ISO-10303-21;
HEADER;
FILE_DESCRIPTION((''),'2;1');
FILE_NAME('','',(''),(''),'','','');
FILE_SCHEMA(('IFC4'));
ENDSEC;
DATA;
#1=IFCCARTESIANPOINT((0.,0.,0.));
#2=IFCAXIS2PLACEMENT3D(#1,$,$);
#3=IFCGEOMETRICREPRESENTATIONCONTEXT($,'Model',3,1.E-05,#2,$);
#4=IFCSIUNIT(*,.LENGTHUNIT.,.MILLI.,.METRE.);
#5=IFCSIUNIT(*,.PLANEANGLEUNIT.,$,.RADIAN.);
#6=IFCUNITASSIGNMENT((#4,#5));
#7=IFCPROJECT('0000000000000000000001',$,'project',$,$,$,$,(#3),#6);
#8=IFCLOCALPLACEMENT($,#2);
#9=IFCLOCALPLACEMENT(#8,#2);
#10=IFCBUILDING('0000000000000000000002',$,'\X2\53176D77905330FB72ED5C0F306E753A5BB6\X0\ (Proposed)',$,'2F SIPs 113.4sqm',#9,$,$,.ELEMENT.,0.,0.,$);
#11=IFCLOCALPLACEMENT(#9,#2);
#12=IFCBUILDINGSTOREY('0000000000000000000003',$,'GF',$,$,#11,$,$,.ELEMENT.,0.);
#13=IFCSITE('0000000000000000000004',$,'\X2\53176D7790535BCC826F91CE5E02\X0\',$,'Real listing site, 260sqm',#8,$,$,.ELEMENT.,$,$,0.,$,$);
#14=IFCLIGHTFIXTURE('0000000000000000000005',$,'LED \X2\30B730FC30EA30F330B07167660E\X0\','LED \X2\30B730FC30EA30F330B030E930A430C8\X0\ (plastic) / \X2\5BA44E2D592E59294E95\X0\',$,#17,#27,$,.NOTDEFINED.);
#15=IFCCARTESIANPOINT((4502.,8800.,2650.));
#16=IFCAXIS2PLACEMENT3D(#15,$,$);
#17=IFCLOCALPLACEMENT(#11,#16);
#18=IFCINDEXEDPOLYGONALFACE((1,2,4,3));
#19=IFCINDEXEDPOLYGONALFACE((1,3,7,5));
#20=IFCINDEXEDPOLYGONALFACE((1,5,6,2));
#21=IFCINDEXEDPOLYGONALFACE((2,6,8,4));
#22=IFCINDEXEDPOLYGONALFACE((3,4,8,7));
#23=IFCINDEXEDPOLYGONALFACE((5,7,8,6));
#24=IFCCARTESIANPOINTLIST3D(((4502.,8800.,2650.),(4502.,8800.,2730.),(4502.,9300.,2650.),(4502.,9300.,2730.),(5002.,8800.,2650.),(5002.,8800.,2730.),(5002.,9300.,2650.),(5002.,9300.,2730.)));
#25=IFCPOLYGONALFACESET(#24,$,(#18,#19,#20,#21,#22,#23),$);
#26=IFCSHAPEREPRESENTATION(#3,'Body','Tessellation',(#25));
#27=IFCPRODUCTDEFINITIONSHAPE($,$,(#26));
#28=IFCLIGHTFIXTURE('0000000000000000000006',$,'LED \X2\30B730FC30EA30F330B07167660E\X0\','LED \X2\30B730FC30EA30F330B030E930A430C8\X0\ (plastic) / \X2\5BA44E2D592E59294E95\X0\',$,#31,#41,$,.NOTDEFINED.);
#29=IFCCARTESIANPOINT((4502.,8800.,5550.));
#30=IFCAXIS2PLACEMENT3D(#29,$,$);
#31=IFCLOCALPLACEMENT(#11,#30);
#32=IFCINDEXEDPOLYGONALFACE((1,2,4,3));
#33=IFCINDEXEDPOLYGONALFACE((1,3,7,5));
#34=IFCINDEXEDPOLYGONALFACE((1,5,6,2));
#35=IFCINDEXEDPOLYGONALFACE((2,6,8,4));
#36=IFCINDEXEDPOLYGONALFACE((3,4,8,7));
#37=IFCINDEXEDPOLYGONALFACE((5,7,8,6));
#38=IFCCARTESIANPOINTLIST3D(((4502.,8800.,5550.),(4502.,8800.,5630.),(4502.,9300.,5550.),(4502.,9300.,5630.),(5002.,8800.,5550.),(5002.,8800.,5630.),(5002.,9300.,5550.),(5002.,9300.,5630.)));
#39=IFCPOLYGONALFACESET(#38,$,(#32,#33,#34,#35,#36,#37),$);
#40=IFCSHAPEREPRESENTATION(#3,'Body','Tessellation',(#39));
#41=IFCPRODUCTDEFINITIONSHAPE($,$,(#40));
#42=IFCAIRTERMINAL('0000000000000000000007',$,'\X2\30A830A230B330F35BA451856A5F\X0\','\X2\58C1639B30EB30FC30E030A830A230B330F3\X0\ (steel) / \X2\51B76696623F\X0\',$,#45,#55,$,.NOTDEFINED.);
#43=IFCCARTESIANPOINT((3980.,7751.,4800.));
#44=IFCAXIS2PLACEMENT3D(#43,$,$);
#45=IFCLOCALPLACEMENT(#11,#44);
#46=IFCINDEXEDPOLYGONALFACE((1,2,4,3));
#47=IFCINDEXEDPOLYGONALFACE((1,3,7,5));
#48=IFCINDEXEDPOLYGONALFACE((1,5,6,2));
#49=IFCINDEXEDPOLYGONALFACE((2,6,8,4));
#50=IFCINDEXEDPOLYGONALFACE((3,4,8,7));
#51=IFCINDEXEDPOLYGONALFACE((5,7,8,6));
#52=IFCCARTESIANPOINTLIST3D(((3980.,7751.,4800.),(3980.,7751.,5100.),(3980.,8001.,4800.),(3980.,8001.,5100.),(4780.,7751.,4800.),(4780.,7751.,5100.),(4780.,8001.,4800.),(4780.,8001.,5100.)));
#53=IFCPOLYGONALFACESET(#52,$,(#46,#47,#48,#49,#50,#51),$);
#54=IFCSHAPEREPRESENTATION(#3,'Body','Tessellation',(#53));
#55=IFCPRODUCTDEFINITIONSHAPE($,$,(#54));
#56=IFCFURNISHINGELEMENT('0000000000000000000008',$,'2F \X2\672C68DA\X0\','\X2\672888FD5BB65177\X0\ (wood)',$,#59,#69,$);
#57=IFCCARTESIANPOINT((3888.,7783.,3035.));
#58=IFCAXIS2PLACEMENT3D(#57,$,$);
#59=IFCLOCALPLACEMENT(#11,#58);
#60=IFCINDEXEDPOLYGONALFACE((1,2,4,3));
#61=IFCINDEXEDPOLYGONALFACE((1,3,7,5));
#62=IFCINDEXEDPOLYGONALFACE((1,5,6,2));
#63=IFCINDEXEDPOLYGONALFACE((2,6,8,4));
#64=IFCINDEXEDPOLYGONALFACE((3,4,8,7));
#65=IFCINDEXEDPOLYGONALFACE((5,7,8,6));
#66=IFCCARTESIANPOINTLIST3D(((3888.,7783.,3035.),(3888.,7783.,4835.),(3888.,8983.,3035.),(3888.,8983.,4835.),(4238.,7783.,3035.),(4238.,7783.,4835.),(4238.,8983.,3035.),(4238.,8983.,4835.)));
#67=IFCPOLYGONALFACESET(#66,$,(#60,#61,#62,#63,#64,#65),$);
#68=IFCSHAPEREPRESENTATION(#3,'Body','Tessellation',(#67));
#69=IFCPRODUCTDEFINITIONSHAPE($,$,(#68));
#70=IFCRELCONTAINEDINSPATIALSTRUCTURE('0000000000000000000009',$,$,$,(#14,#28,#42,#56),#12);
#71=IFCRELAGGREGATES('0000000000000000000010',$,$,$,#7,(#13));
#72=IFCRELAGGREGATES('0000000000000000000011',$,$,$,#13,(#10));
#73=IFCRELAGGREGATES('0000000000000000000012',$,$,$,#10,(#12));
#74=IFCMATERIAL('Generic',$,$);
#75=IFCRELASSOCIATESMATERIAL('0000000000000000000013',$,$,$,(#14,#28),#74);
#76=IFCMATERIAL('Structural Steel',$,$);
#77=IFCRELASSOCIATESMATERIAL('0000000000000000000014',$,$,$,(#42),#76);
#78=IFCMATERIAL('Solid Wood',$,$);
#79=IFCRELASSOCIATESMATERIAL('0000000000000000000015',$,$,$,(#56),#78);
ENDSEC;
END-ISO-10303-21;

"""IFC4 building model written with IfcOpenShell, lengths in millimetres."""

from ifc_helpers import new_model, si_unit, frame, frame_2d, origin, place, context, project, spatial, rectangle, extrude, material, element, save


model = new_model("IFC4")

# Units and contexts
model_context = context("Model", 3, precision=1e-05, world=origin())
ifc_project = project(units=[si_unit("LENGTHUNIT", "METRE", prefix="MILLI"), si_unit("PLANEANGLEUNIT", "RADIAN")], contexts=[model_context])

# Site, building, storey
site_placement = place(None, origin())
site = spatial("IfcSite", under=ifc_project, at=site_placement, Name="北海道富良野市", ObjectType="Real listing site, 260sqm", CompositionType="ELEMENT", RefElevation=0.0)
building_placement = place(site_placement, origin())
building = spatial("IfcBuilding", under=site, at=building_placement, Name="北海道・狭小の町家 (Proposed)", ObjectType="2F SIPs 113.4sqm", CompositionType="ELEMENT", ElevationOfRefHeight=0.0, ElevationOfTerrain=0.0)
storey_placement = place(building_placement, origin())
storey = spatial("IfcBuildingStorey", under=building, at=storey_placement, Name="GF", CompositionType="ELEMENT", Elevation=0.0)

# Shared definitions
ifc_material_1 = material(Name="Solid Wood")

# Shared definitions
ifc_material_2 = material(Name="Structural Steel")

# Shared definitions
ifc_material_3 = material(Name="Generic")

# Light fixtures
light_fixture_1_placement = place(storey_placement, frame((4502.0, 8800.0, 2650.0)))
element("IfcLightFixture", 1, at=light_fixture_1_placement, inside=storey, material=ifc_material_3, Name="LED シーリング照明", Description="LED シーリングライト (plastic) / 室中央天井", PredefinedType="NOTDEFINED", context=model_context, shape_type="SweptSolid", body=[
    extrude(rectangle(XDim=500.0, YDim=500.0, at=frame_2d((250.0, 250.0))), frame((4502.0, 8800.0, 2650.0)), (0.0, 0.0, 1.0), 80.0),
])
light_fixture_2_placement = place(storey_placement, frame((4502.0, 8800.0, 5550.0)))
element("IfcLightFixture", 2, at=light_fixture_2_placement, inside=storey, material=ifc_material_3, Name="LED シーリング照明", Description="LED シーリングライト (plastic) / 室中央天井", PredefinedType="NOTDEFINED", context=model_context, shape_type="SweptSolid", body=[
    extrude(rectangle(XDim=500.0, YDim=500.0, at=frame_2d((250.0, 250.0))), frame((4502.0, 8800.0, 5550.0)), (0.0, 0.0, 1.0), 80.0),
])

# Air terminal
air_terminal_placement = place(storey_placement, frame((3980.0, 7751.0, 4800.0)))
element("IfcAirTerminal", 3, at=air_terminal_placement, inside=storey, material=ifc_material_2, Name="エアコン室内機", Description="壁掛ルームエアコン (steel) / 冷暖房", PredefinedType="NOTDEFINED", context=model_context, shape_type="SweptSolid", body=[
    extrude(rectangle(XDim=800.0, YDim=250.0, at=frame_2d((400.0, 125.0))), frame((3980.0, 7751.0, 4800.0)), (0.0, 0.0, 1.0), 300.0),
])

# Furnishing element
furnishing_placement = place(storey_placement, frame((3888.0, 7783.0, 3035.0)))
element("IfcFurnishingElement", 4, at=furnishing_placement, inside=storey, material=ifc_material_1, Name="2F 本棚", Description="木製家具 (wood)", context=model_context, shape_type="SweptSolid", body=[
    extrude(rectangle(XDim=350.0, YDim=1200.0, at=frame_2d((175.0, 600.0))), frame((3888.0, 7783.0, 3035.0)), (0.0, 0.0, 1.0), 1800.0),
])

save(model, "model.ifc")
